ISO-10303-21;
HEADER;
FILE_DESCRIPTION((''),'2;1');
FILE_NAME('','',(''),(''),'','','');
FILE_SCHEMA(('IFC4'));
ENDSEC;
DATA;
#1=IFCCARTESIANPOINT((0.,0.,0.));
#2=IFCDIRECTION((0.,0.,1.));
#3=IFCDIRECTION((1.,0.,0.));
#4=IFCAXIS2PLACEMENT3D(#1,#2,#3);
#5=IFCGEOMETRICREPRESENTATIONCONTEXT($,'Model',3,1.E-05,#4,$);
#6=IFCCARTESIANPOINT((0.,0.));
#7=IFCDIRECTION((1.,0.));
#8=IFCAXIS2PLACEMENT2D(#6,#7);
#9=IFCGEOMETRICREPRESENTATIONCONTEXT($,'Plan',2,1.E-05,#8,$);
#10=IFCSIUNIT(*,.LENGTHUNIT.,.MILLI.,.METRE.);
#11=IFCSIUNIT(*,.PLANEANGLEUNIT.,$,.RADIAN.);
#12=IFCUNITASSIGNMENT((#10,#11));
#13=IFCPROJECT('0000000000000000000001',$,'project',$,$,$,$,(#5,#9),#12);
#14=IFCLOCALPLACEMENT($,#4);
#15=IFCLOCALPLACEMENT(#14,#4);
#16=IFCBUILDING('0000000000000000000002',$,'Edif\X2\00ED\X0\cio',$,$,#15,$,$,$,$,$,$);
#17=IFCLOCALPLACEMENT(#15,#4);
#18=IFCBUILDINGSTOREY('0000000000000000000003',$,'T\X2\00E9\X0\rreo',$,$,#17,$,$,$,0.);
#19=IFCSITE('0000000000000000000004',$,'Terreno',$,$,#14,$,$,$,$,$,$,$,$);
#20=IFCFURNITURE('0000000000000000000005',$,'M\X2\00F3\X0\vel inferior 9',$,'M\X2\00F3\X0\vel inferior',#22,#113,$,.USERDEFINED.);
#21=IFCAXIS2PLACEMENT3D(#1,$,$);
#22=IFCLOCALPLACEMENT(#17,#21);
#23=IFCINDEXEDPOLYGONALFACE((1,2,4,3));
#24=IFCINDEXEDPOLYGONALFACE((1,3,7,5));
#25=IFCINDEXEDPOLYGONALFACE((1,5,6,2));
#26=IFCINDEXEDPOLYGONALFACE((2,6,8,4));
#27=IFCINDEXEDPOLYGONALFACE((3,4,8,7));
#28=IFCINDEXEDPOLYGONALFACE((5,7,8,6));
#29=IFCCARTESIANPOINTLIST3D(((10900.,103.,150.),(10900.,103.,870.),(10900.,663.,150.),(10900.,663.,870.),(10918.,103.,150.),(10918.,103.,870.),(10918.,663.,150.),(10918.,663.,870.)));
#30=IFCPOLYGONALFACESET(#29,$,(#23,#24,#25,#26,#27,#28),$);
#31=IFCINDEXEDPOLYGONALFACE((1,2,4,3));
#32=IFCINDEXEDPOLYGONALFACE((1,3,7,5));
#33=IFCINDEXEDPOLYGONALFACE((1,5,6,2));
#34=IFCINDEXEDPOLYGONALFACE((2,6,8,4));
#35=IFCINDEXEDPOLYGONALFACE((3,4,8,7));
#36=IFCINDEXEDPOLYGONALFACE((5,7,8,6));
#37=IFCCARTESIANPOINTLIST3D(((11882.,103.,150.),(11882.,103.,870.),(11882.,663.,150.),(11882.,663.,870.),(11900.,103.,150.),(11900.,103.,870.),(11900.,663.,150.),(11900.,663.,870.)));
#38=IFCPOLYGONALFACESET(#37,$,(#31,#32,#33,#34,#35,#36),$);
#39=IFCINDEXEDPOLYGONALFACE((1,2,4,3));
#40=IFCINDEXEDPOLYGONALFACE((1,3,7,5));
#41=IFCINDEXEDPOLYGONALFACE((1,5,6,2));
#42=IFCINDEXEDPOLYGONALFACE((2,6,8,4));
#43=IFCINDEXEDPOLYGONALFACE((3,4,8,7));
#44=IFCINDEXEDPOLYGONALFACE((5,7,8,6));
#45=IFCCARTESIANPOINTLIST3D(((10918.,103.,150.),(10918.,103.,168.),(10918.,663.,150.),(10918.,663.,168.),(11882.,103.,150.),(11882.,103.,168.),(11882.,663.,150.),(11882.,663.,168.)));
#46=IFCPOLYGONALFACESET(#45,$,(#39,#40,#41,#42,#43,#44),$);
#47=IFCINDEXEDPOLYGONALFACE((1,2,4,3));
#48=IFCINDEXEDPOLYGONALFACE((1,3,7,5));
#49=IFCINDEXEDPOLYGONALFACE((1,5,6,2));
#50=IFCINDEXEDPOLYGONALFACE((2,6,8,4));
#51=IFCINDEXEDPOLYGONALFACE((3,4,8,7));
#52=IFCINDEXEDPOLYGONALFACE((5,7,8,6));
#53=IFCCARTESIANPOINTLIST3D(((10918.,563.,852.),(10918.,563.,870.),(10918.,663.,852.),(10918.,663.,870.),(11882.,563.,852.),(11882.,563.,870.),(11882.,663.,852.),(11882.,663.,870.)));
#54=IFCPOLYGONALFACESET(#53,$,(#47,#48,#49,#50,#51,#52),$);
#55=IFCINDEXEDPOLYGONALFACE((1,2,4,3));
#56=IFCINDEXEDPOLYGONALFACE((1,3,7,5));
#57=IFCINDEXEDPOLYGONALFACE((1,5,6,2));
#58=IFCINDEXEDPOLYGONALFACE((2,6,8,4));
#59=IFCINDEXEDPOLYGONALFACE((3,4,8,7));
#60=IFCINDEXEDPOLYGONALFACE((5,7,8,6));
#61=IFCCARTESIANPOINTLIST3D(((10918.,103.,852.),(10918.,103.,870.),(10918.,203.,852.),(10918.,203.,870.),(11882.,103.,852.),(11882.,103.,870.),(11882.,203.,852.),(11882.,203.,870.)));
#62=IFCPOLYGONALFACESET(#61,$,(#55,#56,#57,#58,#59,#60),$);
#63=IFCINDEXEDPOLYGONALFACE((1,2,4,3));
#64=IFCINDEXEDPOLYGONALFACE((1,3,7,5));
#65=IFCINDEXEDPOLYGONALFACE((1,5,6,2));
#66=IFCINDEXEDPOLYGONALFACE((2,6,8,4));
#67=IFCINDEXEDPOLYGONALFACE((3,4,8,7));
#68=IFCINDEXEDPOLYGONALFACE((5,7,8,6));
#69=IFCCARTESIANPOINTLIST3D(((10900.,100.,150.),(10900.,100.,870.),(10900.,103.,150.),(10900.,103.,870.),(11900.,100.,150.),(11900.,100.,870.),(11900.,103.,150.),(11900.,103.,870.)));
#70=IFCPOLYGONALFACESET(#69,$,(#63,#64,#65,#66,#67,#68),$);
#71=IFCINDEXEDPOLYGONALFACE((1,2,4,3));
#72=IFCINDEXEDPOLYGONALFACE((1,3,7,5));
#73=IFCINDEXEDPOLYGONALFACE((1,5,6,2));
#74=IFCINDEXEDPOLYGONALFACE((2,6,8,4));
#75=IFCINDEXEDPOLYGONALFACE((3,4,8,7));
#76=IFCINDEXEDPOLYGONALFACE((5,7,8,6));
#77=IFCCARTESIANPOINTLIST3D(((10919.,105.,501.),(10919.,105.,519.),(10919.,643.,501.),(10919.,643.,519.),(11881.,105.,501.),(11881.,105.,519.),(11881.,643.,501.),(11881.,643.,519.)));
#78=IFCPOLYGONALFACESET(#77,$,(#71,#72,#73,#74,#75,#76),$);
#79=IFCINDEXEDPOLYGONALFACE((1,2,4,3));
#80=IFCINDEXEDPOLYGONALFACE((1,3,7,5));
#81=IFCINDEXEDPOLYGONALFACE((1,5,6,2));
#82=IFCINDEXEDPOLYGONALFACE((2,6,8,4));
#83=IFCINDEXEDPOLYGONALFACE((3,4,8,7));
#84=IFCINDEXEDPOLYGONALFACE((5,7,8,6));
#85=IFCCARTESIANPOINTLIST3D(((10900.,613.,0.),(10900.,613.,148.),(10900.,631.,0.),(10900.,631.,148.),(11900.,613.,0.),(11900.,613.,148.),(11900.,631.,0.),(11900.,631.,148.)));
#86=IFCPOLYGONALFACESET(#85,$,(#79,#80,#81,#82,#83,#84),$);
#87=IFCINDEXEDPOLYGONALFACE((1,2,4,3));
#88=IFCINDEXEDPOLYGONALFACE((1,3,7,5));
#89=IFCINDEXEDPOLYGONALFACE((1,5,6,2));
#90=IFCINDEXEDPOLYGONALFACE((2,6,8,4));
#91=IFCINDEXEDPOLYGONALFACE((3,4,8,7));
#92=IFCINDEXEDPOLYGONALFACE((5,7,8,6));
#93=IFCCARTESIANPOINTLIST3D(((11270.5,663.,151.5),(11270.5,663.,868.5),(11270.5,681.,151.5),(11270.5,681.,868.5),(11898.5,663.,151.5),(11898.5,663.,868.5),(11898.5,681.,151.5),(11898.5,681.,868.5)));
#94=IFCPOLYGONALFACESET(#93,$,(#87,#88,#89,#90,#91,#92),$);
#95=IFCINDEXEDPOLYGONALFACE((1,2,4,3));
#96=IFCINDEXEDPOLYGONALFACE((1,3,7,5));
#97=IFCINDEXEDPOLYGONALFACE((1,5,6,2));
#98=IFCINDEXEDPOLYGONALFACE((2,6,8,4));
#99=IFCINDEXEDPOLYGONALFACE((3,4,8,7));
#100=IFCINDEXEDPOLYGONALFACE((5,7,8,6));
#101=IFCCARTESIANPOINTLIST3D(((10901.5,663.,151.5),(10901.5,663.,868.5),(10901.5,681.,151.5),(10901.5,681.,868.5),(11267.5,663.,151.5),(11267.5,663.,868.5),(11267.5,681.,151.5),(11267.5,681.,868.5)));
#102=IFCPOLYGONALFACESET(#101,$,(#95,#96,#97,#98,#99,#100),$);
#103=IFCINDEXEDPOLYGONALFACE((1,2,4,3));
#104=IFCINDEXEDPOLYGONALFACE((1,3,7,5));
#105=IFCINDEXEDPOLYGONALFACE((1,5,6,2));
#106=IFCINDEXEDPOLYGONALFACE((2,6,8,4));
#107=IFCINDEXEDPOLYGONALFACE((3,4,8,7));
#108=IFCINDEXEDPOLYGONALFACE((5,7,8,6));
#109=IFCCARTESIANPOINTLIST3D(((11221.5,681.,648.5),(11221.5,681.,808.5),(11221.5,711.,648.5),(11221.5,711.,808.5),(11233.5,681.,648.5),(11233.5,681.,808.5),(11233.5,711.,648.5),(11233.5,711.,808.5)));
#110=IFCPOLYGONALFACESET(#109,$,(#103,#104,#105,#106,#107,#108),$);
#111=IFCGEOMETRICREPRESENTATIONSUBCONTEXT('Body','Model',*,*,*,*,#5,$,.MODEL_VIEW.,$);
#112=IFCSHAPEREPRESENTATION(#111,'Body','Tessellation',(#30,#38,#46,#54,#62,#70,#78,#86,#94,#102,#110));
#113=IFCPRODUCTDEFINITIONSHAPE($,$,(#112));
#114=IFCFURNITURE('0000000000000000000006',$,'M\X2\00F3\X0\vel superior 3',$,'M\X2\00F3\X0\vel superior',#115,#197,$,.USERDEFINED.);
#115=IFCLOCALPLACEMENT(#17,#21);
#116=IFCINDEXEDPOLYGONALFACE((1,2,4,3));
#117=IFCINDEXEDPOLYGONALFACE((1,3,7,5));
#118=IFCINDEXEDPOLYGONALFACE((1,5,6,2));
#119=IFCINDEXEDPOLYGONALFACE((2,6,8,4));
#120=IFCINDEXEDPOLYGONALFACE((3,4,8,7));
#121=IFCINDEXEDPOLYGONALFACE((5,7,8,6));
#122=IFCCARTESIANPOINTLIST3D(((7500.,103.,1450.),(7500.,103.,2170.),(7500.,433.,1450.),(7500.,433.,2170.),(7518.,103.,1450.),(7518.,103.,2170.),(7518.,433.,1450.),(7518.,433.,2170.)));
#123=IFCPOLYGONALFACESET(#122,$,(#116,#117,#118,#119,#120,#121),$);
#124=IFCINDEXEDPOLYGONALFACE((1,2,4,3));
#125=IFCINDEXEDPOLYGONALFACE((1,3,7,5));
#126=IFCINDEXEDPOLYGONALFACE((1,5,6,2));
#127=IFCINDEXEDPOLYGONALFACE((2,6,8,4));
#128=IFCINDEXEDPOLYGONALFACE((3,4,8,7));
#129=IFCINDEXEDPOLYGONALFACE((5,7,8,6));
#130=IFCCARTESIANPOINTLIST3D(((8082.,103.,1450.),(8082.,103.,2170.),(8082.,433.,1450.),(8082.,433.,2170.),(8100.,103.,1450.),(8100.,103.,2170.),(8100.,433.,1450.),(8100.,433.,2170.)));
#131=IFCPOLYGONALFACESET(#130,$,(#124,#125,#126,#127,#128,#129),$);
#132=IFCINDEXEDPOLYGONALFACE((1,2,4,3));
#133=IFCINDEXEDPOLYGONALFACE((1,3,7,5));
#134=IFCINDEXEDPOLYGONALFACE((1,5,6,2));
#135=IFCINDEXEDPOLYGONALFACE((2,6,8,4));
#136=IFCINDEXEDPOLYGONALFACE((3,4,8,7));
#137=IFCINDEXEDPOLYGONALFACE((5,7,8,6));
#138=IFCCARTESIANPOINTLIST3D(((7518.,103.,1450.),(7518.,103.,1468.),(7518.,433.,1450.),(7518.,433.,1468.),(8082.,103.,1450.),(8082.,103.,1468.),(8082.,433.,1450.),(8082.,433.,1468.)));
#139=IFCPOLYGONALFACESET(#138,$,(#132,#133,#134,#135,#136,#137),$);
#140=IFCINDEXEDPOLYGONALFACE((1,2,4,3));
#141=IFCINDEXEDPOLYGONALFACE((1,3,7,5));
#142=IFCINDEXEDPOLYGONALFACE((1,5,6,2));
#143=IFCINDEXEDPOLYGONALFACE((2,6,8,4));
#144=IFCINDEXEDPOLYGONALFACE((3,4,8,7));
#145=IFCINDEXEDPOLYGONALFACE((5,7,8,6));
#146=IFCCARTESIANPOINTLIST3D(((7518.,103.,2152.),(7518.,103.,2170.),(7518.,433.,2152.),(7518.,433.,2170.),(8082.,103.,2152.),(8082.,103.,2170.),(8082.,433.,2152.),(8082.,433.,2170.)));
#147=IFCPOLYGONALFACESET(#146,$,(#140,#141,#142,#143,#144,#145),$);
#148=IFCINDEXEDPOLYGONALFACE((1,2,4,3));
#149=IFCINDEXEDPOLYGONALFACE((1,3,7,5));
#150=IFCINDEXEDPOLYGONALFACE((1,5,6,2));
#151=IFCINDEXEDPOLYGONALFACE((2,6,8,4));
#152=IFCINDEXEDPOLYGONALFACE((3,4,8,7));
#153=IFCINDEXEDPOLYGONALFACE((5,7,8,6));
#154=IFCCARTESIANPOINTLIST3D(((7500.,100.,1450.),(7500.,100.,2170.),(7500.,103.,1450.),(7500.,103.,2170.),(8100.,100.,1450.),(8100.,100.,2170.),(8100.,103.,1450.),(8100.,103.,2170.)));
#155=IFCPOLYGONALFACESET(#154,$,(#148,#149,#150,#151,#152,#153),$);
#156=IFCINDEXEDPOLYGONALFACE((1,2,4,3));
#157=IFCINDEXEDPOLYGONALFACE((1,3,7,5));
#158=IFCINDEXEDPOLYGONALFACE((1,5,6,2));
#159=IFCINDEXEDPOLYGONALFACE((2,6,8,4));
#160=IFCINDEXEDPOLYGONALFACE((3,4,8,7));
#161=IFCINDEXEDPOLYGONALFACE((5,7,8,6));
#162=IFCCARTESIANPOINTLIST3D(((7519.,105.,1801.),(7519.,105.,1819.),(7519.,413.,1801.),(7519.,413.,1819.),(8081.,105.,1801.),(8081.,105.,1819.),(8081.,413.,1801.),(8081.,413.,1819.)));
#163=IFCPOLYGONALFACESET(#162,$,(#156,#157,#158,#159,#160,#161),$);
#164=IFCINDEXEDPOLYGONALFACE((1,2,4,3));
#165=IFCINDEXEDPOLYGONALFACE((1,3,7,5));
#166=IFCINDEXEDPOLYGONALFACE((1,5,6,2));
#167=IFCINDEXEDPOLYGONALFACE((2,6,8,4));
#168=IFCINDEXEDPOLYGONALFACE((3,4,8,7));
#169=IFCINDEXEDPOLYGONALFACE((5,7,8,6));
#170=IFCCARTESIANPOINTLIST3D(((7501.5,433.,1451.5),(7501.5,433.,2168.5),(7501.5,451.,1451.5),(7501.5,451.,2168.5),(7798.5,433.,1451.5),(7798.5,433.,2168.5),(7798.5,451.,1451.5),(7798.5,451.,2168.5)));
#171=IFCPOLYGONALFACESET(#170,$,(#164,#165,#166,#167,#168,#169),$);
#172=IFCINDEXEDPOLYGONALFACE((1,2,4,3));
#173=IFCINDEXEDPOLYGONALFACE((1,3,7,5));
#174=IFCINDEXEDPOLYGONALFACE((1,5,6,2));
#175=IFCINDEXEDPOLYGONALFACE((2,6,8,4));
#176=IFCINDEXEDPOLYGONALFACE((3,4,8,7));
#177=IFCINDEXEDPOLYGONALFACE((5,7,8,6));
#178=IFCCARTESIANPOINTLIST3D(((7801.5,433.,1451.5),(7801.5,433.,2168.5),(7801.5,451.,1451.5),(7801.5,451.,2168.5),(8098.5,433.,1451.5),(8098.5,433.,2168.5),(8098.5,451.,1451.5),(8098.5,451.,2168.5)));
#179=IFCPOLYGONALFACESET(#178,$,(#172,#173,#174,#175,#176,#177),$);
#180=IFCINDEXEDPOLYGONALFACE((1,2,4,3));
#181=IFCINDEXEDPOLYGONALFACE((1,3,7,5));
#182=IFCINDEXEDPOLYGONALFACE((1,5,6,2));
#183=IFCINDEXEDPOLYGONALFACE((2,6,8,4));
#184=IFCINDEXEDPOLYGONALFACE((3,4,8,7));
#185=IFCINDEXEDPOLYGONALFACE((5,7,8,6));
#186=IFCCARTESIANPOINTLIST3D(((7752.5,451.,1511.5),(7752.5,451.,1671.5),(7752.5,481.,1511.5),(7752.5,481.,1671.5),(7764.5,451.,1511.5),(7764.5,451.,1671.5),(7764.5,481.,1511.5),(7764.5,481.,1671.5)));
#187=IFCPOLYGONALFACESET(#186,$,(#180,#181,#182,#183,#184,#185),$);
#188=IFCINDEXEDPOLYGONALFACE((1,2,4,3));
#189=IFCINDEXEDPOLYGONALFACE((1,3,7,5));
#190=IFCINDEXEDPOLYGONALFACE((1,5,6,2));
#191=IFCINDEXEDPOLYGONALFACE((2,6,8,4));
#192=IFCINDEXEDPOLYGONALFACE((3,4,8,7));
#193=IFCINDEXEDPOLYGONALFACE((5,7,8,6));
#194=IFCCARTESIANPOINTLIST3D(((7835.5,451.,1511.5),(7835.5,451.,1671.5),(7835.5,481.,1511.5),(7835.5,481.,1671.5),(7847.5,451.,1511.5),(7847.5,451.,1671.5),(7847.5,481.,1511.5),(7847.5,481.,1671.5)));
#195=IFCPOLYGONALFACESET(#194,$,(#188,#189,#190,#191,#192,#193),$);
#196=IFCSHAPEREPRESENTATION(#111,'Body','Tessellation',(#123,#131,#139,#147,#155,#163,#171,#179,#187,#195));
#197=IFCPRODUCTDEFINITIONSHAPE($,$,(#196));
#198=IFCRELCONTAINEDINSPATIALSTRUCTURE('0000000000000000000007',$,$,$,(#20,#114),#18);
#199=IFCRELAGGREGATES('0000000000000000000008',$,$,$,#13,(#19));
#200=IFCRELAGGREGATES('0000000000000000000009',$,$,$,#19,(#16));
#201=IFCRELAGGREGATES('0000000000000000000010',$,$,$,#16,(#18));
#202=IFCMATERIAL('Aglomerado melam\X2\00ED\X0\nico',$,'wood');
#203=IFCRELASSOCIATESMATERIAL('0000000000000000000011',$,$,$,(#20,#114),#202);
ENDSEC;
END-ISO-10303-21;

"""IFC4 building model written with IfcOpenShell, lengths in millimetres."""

from ifc_helpers import new_model, si_unit, frame, frame_2d, origin, origin_with_axes, origin_2d_with_axis, place, context, subcontext, project, spatial, rectangle, extrude, material, element, save


model = new_model("IFC4")

# Units and contexts
model_context = context("Model", 3, precision=1e-05, world=origin_with_axes())
plan_context = context("Plan", 2, precision=1e-05, world=origin_2d_with_axis())
body_context = subcontext(model_context, "Body", "Model", "MODEL_VIEW")
ifc_project = project(units=[si_unit("LENGTHUNIT", "METRE", prefix="MILLI"), si_unit("PLANEANGLEUNIT", "RADIAN")], contexts=[model_context, plan_context])

# Site, building, storey
site_placement = place(None, origin_with_axes())
site = spatial("IfcSite", under=ifc_project, at=site_placement, Name="Terreno")
building_placement = place(site_placement, origin_with_axes())
building = spatial("IfcBuilding", under=site, at=building_placement, Name="Edifício")
storey_placement = place(building_placement, origin_with_axes())
storey = spatial("IfcBuildingStorey", under=building, at=storey_placement, Name="Térreo", Elevation=0.0)

# Furniture
ifc_material_1 = material(Name="Aglomerado melamínico", Category="wood")
furniture_1_placement = place(storey_placement, frame((10900.0, 100.0, 0.0), z_axis=(0.0, 0.0, 1.0), x_axis=(1.0, 0.0, 0.0)))
element("IfcFurniture", 1, at=furniture_1_placement, inside=storey, material=ifc_material_1, Name="Móvel inferior 9", ObjectType="Móvel inferior", PredefinedType="USERDEFINED", context=body_context, shape_type="SweptSolid", body=[
    extrude(rectangle(XDim=18.0, YDim=560.0, at=frame_2d((9.0, 283.0))), frame((0.0, 0.0, 150.0)), (0.0, 0.0, 1.0), 720.0),
    extrude(rectangle(XDim=18.0, YDim=560.0, at=frame_2d((991.0, 283.0))), frame((0.0, 0.0, 150.0)), (0.0, 0.0, 1.0), 720.0),
    extrude(rectangle(XDim=964.0, YDim=560.0, at=frame_2d((500.0, 283.0))), frame((0.0, 0.0, 150.0)), (0.0, 0.0, 1.0), 18.0),
    extrude(rectangle(XDim=964.0, YDim=100.0, at=frame_2d((500.0, 513.0))), frame((0.0, 0.0, 852.0)), (0.0, 0.0, 1.0), 18.0),
    extrude(rectangle(XDim=964.0, YDim=100.0, at=frame_2d((500.0, 53.0))), frame((0.0, 0.0, 852.0)), (0.0, 0.0, 1.0), 18.0),
    extrude(rectangle(XDim=1000.0, YDim=3.0, at=frame_2d((500.0, 1.5))), frame((0.0, 0.0, 150.0)), (0.0, 0.0, 1.0), 720.0),
    extrude(rectangle(XDim=962.0, YDim=538.0, at=frame_2d((500.0, 274.0))), frame((0.0, 0.0, 501.0)), (0.0, 0.0, 1.0), 18.0),
    extrude(rectangle(XDim=1000.0, YDim=18.0, at=frame_2d((500.0, 522.0))), origin(), (0.0, 0.0, 1.0), 148.0),
    extrude(rectangle(XDim=628.0, YDim=18.0, at=frame_2d((684.5, 572.0))), frame((0.0, 0.0, 151.5)), (0.0, 0.0, 1.0), 717.0),
    extrude(rectangle(XDim=366.0, YDim=18.0, at=frame_2d((184.5, 572.0))), frame((0.0, 0.0, 151.5)), (0.0, 0.0, 1.0), 717.0),
    extrude(rectangle(XDim=12.0, YDim=30.0, at=frame_2d((327.5, 596.0))), frame((0.0, 0.0, 648.5)), (0.0, 0.0, 1.0), 160.0),
])
for number, where, z_axis, x_axis, name in (
    (2, (7500.0, 100.0, 0.0), (0.0, 0.0, 1.0), (1.0, 0.0, 0.0), "Móvel superior 3"),
):
    element("IfcFurniture", number, at=place(storey_placement, frame(where, z_axis=z_axis, x_axis=x_axis)), inside=storey, material=ifc_material_1, Name=name, ObjectType="Móvel superior", PredefinedType="USERDEFINED", context=body_context, shape_type="SweptSolid", body=[
        extrude(rectangle(XDim=18.0, YDim=330.0, at=frame_2d((9.0, 168.0))), frame((0.0, 0.0, 1450.0)), (0.0, 0.0, 1.0), 720.0),
        extrude(rectangle(XDim=18.0, YDim=330.0, at=frame_2d((591.0, 168.0))), frame((0.0, 0.0, 1450.0)), (0.0, 0.0, 1.0), 720.0),
        extrude(rectangle(XDim=564.0, YDim=330.0, at=frame_2d((300.0, 168.0))), frame((0.0, 0.0, 1450.0)), (0.0, 0.0, 1.0), 18.0),
        extrude(rectangle(XDim=564.0, YDim=330.0, at=frame_2d((300.0, 168.0))), frame((0.0, 0.0, 2152.0)), (0.0, 0.0, 1.0), 18.0),
        extrude(rectangle(XDim=600.0, YDim=3.0, at=frame_2d((300.0, 1.5))), frame((0.0, 0.0, 1450.0)), (0.0, 0.0, 1.0), 720.0),
        extrude(rectangle(XDim=562.0, YDim=308.0, at=frame_2d((300.0, 159.0))), frame((0.0, 0.0, 1801.0)), (0.0, 0.0, 1.0), 18.0),
        extrude(rectangle(XDim=297.0, YDim=18.0, at=frame_2d((150.0, 342.0))), frame((0.0, 0.0, 1451.5)), (0.0, 0.0, 1.0), 717.0),
        extrude(rectangle(XDim=297.0, YDim=18.0, at=frame_2d((450.0, 342.0))), frame((0.0, 0.0, 1451.5)), (0.0, 0.0, 1.0), 717.0),
        extrude(rectangle(XDim=12.0, YDim=30.0, at=frame_2d((258.5, 366.0))), frame((0.0, 0.0, 1511.5)), (0.0, 0.0, 1.0), 160.0),
        extrude(rectangle(XDim=12.0, YDim=30.0, at=frame_2d((341.5, 366.0))), frame((0.0, 0.0, 1511.5)), (0.0, 0.0, 1.0), 160.0),
    ])

save(model, "model.ifc")
